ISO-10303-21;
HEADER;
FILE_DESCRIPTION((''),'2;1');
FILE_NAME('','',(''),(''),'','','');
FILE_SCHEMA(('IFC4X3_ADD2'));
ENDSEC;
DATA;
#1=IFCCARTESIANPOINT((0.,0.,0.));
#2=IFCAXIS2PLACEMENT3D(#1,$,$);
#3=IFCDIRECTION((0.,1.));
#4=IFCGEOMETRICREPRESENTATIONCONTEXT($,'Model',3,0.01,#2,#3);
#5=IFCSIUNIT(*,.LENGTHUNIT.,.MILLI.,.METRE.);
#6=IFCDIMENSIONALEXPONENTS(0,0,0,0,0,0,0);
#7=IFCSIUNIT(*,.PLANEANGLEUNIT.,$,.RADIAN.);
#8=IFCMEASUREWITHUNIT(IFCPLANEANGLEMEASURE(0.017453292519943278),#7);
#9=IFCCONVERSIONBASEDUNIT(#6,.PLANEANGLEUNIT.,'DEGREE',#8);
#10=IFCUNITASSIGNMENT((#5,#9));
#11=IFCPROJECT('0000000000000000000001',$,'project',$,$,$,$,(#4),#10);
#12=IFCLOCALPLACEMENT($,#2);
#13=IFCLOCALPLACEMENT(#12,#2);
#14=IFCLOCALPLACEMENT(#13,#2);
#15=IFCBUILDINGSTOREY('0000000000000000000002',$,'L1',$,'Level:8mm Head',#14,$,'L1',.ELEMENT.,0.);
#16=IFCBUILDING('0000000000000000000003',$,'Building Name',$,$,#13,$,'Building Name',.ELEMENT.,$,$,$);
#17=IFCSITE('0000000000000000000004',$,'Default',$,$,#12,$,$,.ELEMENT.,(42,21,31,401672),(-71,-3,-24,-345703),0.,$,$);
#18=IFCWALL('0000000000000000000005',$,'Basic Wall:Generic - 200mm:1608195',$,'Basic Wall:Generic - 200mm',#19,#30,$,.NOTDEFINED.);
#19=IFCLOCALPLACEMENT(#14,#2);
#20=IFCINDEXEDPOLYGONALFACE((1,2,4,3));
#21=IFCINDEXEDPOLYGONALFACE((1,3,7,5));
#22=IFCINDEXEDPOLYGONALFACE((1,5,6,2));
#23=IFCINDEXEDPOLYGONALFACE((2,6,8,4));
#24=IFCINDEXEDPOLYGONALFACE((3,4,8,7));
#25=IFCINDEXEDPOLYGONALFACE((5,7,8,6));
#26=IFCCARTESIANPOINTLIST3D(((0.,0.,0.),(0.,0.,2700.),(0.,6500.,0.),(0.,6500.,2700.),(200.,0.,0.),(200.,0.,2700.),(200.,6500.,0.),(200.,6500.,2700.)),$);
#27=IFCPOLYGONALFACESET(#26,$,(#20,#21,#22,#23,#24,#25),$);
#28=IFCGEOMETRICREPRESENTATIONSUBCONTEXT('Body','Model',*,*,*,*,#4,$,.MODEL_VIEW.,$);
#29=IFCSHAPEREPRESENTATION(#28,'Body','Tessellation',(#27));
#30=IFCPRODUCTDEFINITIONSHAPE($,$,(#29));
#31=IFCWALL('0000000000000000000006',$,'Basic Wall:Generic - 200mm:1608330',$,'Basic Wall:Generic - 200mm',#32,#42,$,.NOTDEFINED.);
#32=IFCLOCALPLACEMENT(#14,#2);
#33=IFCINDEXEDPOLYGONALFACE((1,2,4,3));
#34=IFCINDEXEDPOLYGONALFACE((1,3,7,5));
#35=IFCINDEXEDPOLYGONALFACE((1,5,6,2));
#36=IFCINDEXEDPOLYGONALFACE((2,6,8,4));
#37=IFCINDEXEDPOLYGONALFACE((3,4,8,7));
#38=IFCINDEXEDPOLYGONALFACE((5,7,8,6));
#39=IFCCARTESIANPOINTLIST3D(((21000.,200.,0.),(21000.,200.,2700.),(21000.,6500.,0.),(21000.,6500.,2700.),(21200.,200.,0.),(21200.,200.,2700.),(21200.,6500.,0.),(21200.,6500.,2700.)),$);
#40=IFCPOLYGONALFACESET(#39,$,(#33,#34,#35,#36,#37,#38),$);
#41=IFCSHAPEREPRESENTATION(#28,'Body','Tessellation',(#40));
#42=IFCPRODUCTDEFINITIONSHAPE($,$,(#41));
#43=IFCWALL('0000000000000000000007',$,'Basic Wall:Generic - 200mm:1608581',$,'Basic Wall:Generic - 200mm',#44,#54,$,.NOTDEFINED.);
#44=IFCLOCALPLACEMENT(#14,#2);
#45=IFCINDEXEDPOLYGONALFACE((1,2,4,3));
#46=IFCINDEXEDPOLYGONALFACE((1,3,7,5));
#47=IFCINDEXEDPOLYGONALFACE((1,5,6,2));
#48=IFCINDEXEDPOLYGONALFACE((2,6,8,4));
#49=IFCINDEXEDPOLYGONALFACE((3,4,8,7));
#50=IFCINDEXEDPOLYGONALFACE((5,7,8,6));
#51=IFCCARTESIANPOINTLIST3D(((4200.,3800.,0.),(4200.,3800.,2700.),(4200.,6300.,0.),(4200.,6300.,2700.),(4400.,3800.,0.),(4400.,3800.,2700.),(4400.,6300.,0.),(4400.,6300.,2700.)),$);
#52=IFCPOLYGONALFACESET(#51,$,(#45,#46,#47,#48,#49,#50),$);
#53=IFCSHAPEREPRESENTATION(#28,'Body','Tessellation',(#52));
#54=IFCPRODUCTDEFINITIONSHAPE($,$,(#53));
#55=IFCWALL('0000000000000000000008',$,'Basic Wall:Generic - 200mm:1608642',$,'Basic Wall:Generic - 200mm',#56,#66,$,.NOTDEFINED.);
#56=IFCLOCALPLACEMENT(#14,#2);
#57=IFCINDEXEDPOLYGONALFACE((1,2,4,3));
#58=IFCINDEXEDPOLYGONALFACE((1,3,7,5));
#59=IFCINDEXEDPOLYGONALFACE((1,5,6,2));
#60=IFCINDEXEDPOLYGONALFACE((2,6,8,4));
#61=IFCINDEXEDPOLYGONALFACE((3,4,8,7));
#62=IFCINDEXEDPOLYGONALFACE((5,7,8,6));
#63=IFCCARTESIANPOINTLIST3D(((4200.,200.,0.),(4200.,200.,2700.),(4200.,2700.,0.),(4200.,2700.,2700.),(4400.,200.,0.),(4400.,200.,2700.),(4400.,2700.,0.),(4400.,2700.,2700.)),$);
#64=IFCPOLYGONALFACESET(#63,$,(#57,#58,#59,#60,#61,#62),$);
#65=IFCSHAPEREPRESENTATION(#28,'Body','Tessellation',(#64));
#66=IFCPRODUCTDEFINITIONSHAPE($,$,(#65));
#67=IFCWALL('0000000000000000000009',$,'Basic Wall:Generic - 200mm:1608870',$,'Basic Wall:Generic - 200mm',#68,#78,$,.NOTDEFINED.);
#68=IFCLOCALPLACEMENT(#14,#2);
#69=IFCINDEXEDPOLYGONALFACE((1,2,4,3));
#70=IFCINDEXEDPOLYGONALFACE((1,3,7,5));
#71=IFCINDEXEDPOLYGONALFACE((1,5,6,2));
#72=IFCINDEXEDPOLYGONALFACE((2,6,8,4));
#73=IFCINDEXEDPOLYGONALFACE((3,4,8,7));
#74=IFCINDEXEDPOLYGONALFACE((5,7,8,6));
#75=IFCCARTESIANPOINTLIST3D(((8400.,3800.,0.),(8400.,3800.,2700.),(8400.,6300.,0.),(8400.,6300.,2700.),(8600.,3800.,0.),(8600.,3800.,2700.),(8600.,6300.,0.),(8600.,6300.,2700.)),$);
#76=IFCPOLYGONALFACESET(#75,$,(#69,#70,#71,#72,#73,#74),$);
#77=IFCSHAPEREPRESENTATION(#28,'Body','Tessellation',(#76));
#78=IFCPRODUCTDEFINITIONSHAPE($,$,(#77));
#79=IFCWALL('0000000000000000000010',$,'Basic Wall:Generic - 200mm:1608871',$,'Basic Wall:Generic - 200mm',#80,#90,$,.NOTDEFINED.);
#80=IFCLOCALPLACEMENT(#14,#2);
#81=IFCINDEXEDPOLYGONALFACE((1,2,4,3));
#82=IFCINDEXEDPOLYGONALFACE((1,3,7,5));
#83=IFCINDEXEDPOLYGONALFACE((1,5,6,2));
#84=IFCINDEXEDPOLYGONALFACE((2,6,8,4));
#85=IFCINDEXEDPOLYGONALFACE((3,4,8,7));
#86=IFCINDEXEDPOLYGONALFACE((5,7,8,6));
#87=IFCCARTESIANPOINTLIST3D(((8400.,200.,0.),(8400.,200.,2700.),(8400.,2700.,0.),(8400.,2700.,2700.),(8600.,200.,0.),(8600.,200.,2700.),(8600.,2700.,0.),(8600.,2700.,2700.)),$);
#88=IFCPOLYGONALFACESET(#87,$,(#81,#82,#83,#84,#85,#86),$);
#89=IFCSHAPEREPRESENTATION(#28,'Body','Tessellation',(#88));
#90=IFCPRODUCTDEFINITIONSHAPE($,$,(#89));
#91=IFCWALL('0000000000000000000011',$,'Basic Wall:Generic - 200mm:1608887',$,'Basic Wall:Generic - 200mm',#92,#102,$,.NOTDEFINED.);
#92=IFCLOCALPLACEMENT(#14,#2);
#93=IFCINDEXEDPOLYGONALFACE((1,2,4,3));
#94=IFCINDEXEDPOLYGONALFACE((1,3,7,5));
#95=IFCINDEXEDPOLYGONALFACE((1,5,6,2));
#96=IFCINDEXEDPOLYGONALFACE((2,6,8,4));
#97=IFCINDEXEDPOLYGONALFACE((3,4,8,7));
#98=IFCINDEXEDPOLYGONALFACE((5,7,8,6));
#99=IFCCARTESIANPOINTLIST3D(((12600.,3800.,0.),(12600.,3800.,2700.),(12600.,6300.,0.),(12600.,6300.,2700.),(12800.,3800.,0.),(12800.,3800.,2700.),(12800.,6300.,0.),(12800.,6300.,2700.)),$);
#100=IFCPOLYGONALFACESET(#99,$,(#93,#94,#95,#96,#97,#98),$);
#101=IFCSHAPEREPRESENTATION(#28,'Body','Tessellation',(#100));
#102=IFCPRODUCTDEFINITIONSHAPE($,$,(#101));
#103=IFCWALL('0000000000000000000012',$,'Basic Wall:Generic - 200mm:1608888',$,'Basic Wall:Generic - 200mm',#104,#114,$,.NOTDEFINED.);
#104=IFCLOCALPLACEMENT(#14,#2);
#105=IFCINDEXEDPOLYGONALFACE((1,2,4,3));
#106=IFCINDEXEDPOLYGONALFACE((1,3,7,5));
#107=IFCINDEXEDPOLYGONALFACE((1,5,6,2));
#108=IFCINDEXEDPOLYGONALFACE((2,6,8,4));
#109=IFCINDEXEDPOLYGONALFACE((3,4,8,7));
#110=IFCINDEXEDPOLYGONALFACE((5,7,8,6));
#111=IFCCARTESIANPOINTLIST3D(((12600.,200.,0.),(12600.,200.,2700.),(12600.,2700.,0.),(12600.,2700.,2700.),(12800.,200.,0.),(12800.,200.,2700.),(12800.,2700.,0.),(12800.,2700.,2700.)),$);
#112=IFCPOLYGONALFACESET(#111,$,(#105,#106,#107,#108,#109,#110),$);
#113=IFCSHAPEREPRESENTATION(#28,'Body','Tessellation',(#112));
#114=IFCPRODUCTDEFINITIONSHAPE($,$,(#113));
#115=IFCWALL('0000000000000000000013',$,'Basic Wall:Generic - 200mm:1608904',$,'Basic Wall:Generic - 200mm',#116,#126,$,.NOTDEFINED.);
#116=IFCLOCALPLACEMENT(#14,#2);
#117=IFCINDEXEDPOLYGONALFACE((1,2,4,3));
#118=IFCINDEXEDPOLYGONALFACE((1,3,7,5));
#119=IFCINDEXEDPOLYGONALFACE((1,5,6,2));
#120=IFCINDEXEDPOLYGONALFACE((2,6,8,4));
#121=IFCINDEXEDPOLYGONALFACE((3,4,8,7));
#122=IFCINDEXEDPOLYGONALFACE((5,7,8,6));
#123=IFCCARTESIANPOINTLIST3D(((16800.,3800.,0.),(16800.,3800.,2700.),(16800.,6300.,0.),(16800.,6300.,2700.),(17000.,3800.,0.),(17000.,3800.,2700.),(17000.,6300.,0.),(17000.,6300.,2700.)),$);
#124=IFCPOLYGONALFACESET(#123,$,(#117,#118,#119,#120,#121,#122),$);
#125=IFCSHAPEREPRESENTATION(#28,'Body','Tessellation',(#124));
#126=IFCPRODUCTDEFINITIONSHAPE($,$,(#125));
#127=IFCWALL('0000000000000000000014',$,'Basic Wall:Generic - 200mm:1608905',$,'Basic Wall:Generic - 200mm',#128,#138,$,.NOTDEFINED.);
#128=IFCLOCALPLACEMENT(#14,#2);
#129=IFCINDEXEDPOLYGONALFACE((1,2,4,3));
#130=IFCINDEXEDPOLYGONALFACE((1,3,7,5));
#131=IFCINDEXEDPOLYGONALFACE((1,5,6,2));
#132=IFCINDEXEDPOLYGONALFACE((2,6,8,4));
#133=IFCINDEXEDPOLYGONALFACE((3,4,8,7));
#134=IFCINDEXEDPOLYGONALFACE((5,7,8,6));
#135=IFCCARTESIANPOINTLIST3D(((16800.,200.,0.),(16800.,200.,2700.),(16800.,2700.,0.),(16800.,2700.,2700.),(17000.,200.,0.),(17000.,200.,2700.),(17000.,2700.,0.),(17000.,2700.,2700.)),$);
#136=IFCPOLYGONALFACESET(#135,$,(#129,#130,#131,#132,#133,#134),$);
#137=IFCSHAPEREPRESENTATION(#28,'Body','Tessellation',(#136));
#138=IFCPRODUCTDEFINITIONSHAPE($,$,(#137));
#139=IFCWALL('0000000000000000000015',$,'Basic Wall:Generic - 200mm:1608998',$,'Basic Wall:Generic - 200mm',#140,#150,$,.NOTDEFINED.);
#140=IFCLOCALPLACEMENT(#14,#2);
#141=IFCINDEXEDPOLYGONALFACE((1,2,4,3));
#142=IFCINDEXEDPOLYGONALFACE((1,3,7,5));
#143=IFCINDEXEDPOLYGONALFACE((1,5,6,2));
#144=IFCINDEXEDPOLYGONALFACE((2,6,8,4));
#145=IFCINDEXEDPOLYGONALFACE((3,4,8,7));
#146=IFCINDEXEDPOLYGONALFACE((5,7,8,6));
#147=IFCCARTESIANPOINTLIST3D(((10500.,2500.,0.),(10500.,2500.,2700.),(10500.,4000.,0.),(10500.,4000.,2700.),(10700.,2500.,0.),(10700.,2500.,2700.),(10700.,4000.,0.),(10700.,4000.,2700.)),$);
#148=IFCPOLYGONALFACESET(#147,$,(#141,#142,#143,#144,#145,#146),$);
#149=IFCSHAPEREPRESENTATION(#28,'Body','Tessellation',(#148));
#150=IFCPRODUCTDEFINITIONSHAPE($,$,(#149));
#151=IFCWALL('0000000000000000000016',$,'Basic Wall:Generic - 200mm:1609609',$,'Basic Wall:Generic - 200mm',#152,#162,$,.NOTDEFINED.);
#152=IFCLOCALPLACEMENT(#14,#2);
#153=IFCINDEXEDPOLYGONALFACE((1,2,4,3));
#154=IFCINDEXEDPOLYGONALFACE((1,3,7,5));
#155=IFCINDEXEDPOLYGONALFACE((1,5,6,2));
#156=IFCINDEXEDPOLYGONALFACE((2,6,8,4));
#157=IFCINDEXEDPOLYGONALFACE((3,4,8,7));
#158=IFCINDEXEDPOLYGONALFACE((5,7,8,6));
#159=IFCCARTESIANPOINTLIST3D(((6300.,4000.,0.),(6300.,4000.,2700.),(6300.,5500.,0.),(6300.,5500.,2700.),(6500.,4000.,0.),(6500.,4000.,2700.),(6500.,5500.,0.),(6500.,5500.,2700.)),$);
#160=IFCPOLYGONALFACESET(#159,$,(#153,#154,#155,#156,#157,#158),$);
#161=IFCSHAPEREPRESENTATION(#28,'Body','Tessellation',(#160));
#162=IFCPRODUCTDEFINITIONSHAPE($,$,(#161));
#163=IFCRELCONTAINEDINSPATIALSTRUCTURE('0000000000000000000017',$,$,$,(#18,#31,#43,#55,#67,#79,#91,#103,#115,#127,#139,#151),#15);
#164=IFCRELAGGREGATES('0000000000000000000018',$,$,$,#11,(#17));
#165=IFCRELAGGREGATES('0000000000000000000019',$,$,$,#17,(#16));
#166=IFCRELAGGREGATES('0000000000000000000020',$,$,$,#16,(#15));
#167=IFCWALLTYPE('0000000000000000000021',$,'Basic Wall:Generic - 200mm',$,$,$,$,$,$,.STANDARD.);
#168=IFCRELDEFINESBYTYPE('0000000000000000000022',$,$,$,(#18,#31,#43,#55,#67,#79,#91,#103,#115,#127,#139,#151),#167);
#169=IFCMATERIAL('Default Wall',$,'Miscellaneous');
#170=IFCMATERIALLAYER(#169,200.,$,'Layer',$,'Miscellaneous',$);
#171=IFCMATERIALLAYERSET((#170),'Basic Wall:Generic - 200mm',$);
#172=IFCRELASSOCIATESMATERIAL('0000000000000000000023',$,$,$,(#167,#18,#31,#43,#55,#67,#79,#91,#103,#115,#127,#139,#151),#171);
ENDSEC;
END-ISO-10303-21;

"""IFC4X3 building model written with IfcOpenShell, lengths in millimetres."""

from ifc_helpers import new_model, entity, si_unit, converted_unit, direction, frame, frame_2d, origin, place, context, subcontext, project, spatial, polyline, rectangle, extrude, clip, bounded_halfspace, material, layer, layer_set, type_object, element, save


model = new_model("IFC4X3")

# Units and contexts
model_context = context("Model", 3, precision=0.01, world=origin(), true_north=direction((0.0, 1.0)))
body_context = subcontext(model_context, "Body", "Model", "MODEL_VIEW")
ifc_project = project(units=[si_unit("LENGTHUNIT", "METRE", prefix="MILLI"), converted_unit("PLANEANGLEUNIT", "DEGREE", entity("IfcPlaneAngleMeasure", 0.017453292519943278), si_unit("PLANEANGLEUNIT", "RADIAN"), dimensions=[0, 0, 0, 0, 0, 0, 0])], contexts=[model_context])

# Site, building, storey
site_placement = place(None, origin())
site = spatial("IfcSite", under=ifc_project, at=site_placement, Name="Default", CompositionType="ELEMENT", RefLatitude=(42, 21, 31, 401672), RefLongitude=(-71, -3, -24, -345703), RefElevation=0.0)
building_placement = place(site_placement, origin())
building = spatial("IfcBuilding", under=site, at=building_placement, Name="Building Name", LongName="Building Name", CompositionType="ELEMENT")
storey_placement = place(building_placement, origin())
storey = spatial("IfcBuildingStorey", under=building, at=storey_placement, Name="L1", ObjectType="Level:8mm Head", LongName="L1", CompositionType="ELEMENT", Elevation=0.0)

# Walls
ifc_material = material(Name="Default Wall", Category="Miscellaneous")
ifc_layer = layer(ifc_material, 200.0, Name="Layer", Category="Miscellaneous")
ifc_layer_set = layer_set([ifc_layer], Name="Basic Wall:Generic - 200mm")
wall_type = type_object("IfcWallType", Name="Basic Wall:Generic - 200mm", PredefinedType="STANDARD", material=ifc_layer_set)
wall_1_placement = place(storey_placement, frame((100.0, 6500.0, 0.0), z_axis=(0.0, 0.0, 1.0), x_axis=(0.0, -1.0, 0.0)))
element("IfcWall", 1, at=wall_1_placement, inside=storey, type_object=wall_type, material=ifc_layer_set, Name="Basic Wall:Generic - 200mm:1608195", ObjectType="Basic Wall:Generic - 200mm", PredefinedType="NOTDEFINED", context=body_context, shape_type="Clipping", body=[
    clip(extrude(rectangle(XDim=6500.0, YDim=200.0, at=frame_2d((3250.0, 0.0), x_axis=(-1.0, 0.0))), origin(), (0.0, 0.0, 1.0), 2700.0), bounded_halfspace(frame((0.0, -100.0, 2700.0), z_axis=(0.0, 0.0, -1.0), x_axis=(0.0, -1.0, 0.0)), True, frame((0.0, -100.0, 2700.0)), polyline([(0.0, 0.0), (6500.0, 0.0), (6500.0, 200.0), (6300.0, 200.0), (200.0, 200.0), (0.0, 200.0), (0.0, 0.0)]))),
])
wall_2_placement = place(storey_placement, frame((21100.0, 200.0, 0.0), z_axis=(0.0, 0.0, 1.0), x_axis=(0.0, 1.0, 0.0)))
element("IfcWall", 2, at=wall_2_placement, inside=storey, type_object=wall_type, material=ifc_layer_set, Name="Basic Wall:Generic - 200mm:1608330", ObjectType="Basic Wall:Generic - 200mm", PredefinedType="NOTDEFINED", context=body_context, shape_type="Clipping", body=[
    clip(extrude(rectangle(XDim=6300.0, YDim=200.0, at=frame_2d((3150.0, 0.0), x_axis=(-1.0, 0.0))), origin(), (0.0, 0.0, 1.0), 2700.0), bounded_halfspace(frame((0.0, -100.0, 2700.0), z_axis=(0.0, 0.0, -1.0), x_axis=(0.0, 1.0, 0.0)), True, frame((0.0, -100.0, 2700.0)), polyline([(0.0, 0.0), (6300.0, 0.0), (6300.0, 200.0), (6100.0, 200.0), (0.0, 200.0), (0.0, 0.0)]))),
])
wall_3_placement = place(storey_placement, frame((4300.0, 6300.0, 0.0), z_axis=(0.0, 0.0, 1.0), x_axis=(0.0, -1.0, 0.0)))
element("IfcWall", 3, at=wall_3_placement, inside=storey, type_object=wall_type, material=ifc_layer_set, Name="Basic Wall:Generic - 200mm:1608581", ObjectType="Basic Wall:Generic - 200mm", PredefinedType="NOTDEFINED", context=body_context, shape_type="Clipping", body=[
    clip(extrude(rectangle(XDim=2500.0, YDim=200.0, at=frame_2d((1250.0, 0.0), x_axis=(-1.0, 0.0))), origin(), (0.0, 0.0, 1.0), 2700.0), bounded_halfspace(frame((0.0, -100.0, 2700.0), z_axis=(0.0, 0.0, -1.0), x_axis=(0.0, -1.0, 0.0)), True, frame((0.0, -100.0, 2700.0)), polyline([(0.0, 0.0), (2500.0, 0.0), (2500.0, 200.0), (0.0, 200.0), (0.0, 0.0)]))),
])
wall_4_placement = place(storey_placement, frame((4300.0, 2700.0, 0.0), z_axis=(0.0, 0.0, 1.0), x_axis=(0.0, -1.0, 0.0)))
element("IfcWall", 4, at=wall_4_placement, inside=storey, type_object=wall_type, material=ifc_layer_set, Name="Basic Wall:Generic - 200mm:1608642", ObjectType="Basic Wall:Generic - 200mm", PredefinedType="NOTDEFINED", context=body_context, shape_type="Clipping", body=[
    clip(extrude(rectangle(XDim=2500.0, YDim=200.0, at=frame_2d((1250.0, 0.0), x_axis=(-1.0, 0.0))), origin(), (0.0, 0.0, 1.0), 2700.0), bounded_halfspace(frame((0.0, -100.0, 2700.0), z_axis=(0.0, 0.0, -1.0), x_axis=(0.0, -1.0, 0.0)), True, frame((0.0, -100.0, 2700.0)), polyline([(0.0, 0.0), (2500.0, 0.0), (2500.0, 200.0), (0.0, 200.0), (0.0, 0.0)]))),
])
wall_5_placement = place(storey_placement, frame((8500.0, 6300.0, 0.0), z_axis=(0.0, 0.0, 1.0), x_axis=(0.0, -1.0, 0.0)))
element("IfcWall", 5, at=wall_5_placement, inside=storey, type_object=wall_type, material=ifc_layer_set, Name="Basic Wall:Generic - 200mm:1608870", ObjectType="Basic Wall:Generic - 200mm", PredefinedType="NOTDEFINED", context=body_context, shape_type="Clipping", body=[
    clip(extrude(rectangle(XDim=2500.0, YDim=200.0, at=frame_2d((1250.0, 0.0), x_axis=(-1.0, 0.0))), origin(), (0.0, 0.0, 1.0), 2700.0), bounded_halfspace(frame((0.0, -100.0, 2700.0), z_axis=(0.0, 0.0, -1.0), x_axis=(0.0, -1.0, 0.0)), True, frame((0.0, -100.0, 2700.0)), polyline([(0.0, 0.0), (2500.0, 0.0), (2500.0, 200.0), (0.0, 200.0), (0.0, 0.0)]))),
])
wall_6_placement = place(storey_placement, frame((8500.0, 2700.0, 0.0), z_axis=(0.0, 0.0, 1.0), x_axis=(0.0, -1.0, 0.0)))
element("IfcWall", 6, at=wall_6_placement, inside=storey, type_object=wall_type, material=ifc_layer_set, Name="Basic Wall:Generic - 200mm:1608871", ObjectType="Basic Wall:Generic - 200mm", PredefinedType="NOTDEFINED", context=body_context, shape_type="Clipping", body=[
    clip(extrude(rectangle(XDim=2500.0, YDim=200.0, at=frame_2d((1250.0, 0.0), x_axis=(-1.0, 0.0))), origin(), (0.0, 0.0, 1.0), 2700.0), bounded_halfspace(frame((0.0, -100.0, 2700.0), z_axis=(0.0, 0.0, -1.0), x_axis=(0.0, -1.0, 0.0)), True, frame((0.0, -100.0, 2700.0)), polyline([(0.0, 0.0), (2500.0, 0.0), (2500.0, 200.0), (0.0, 200.0), (0.0, 0.0)]))),
])
wall_7_placement = place(storey_placement, frame((12700.0, 6300.0, 0.0), z_axis=(0.0, 0.0, 1.0), x_axis=(0.0, -1.0, 0.0)))
element("IfcWall", 7, at=wall_7_placement, inside=storey, type_object=wall_type, material=ifc_layer_set, Name="Basic Wall:Generic - 200mm:1608887", ObjectType="Basic Wall:Generic - 200mm", PredefinedType="NOTDEFINED", context=body_context, shape_type="Clipping", body=[
    clip(extrude(rectangle(XDim=2500.0, YDim=200.0, at=frame_2d((1250.0, 0.0), x_axis=(-1.0, 0.0))), origin(), (0.0, 0.0, 1.0), 2700.0), bounded_halfspace(frame((0.0, -100.0, 2700.0), z_axis=(0.0, 0.0, -1.0), x_axis=(0.0, -1.0, 0.0)), True, frame((0.0, -100.0, 2700.0)), polyline([(0.0, 0.0), (2500.0, 0.0), (2500.0, 200.0), (0.0, 200.0), (0.0, 0.0)]))),
])
wall_8_placement = place(storey_placement, frame((12700.0, 2700.0, 0.0), z_axis=(0.0, 0.0, 1.0), x_axis=(0.0, -1.0, 0.0)))
element("IfcWall", 8, at=wall_8_placement, inside=storey, type_object=wall_type, material=ifc_layer_set, Name="Basic Wall:Generic - 200mm:1608888", ObjectType="Basic Wall:Generic - 200mm", PredefinedType="NOTDEFINED", context=body_context, shape_type="Clipping", body=[
    clip(extrude(rectangle(XDim=2500.0, YDim=200.0, at=frame_2d((1250.0, 0.0), x_axis=(-1.0, 0.0))), origin(), (0.0, 0.0, 1.0), 2700.0), bounded_halfspace(frame((0.0, -100.0, 2700.0), z_axis=(0.0, 0.0, -1.0), x_axis=(0.0, -1.0, 0.0)), True, frame((0.0, -100.0, 2700.0)), polyline([(0.0, 0.0), (2500.0, 0.0), (2500.0, 200.0), (0.0, 200.0), (0.0, 0.0)]))),
])
wall_9_placement = place(storey_placement, frame((16900.0, 6300.0, 0.0), z_axis=(0.0, 0.0, 1.0), x_axis=(0.0, -1.0, 0.0)))
element("IfcWall", 9, at=wall_9_placement, inside=storey, type_object=wall_type, material=ifc_layer_set, Name="Basic Wall:Generic - 200mm:1608904", ObjectType="Basic Wall:Generic - 200mm", PredefinedType="NOTDEFINED", context=body_context, shape_type="Clipping", body=[
    clip(extrude(rectangle(XDim=2500.0, YDim=200.0, at=frame_2d((1250.0, 0.0), x_axis=(-1.0, 0.0))), origin(), (0.0, 0.0, 1.0), 2700.0), bounded_halfspace(frame((0.0, -100.0, 2700.0), z_axis=(0.0, 0.0, -1.0), x_axis=(0.0, -1.0, 0.0)), True, frame((0.0, -100.0, 2700.0)), polyline([(0.0, 0.0), (2500.0, 0.0), (2500.0, 200.0), (0.0, 200.0), (0.0, 0.0)]))),
])
wall_10_placement = place(storey_placement, frame((16900.0, 2700.0, 0.0), z_axis=(0.0, 0.0, 1.0), x_axis=(0.0, -1.0, 0.0)))
element("IfcWall", 10, at=wall_10_placement, inside=storey, type_object=wall_type, material=ifc_layer_set, Name="Basic Wall:Generic - 200mm:1608905", ObjectType="Basic Wall:Generic - 200mm", PredefinedType="NOTDEFINED", context=body_context, shape_type="Clipping", body=[
    clip(extrude(rectangle(XDim=2500.0, YDim=200.0, at=frame_2d((1250.0, 0.0), x_axis=(-1.0, 0.0))), origin(), (0.0, 0.0, 1.0), 2700.0), bounded_halfspace(frame((0.0, -100.0, 2700.0), z_axis=(0.0, 0.0, -1.0), x_axis=(0.0, -1.0, 0.0)), True, frame((0.0, -100.0, 2700.0)), polyline([(0.0, 0.0), (2500.0, 0.0), (2500.0, 200.0), (0.0, 200.0), (0.0, 0.0)]))),
])
wall_11_placement = place(storey_placement, frame((10600.0, 4000.0, 0.0), z_axis=(0.0, 0.0, 1.0), x_axis=(0.0, -1.0, 0.0)))
element("IfcWall", 11, at=wall_11_placement, inside=storey, type_object=wall_type, material=ifc_layer_set, Name="Basic Wall:Generic - 200mm:1608998", ObjectType="Basic Wall:Generic - 200mm", PredefinedType="NOTDEFINED", context=body_context, shape_type="Clipping", body=[
    clip(extrude(rectangle(XDim=1500.0, YDim=200.0, at=frame_2d((750.0, 0.0), x_axis=(-1.0, 0.0))), origin(), (0.0, 0.0, 1.0), 2700.0), bounded_halfspace(frame((0.0, -100.0, 2700.0), z_axis=(0.0, 0.0, -1.0), x_axis=(0.0, -1.0, 0.0)), True, frame((0.0, -100.0, 2700.0)), polyline([(0.0, 0.0), (1500.0, 0.0), (1500.0, 200.0), (0.0, 200.0), (0.0, 0.0)]))),
])
wall_12_placement = place(storey_placement, frame((6400.0, 4000.0, 0.0), z_axis=(0.0, 0.0, 1.0), x_axis=(0.0, 1.0, 0.0)))
element("IfcWall", 12, at=wall_12_placement, inside=storey, type_object=wall_type, material=ifc_layer_set, Name="Basic Wall:Generic - 200mm:1609609", ObjectType="Basic Wall:Generic - 200mm", PredefinedType="NOTDEFINED", context=body_context, shape_type="Clipping", body=[
    clip(extrude(rectangle(XDim=1500.0, YDim=200.0, at=frame_2d((750.0, 0.0), x_axis=(-1.0, 0.0))), origin(), (0.0, 0.0, 1.0), 2700.0), bounded_halfspace(frame((0.0, -100.0, 2700.0), z_axis=(0.0, 0.0, -1.0), x_axis=(0.0, 1.0, 0.0)), True, frame((0.0, -100.0, 2700.0)), polyline([(0.0, 0.0), (1500.0, 0.0), (1500.0, 200.0), (0.0, 200.0), (0.0, 0.0)]))),
])

save(model, "model.ifc")
